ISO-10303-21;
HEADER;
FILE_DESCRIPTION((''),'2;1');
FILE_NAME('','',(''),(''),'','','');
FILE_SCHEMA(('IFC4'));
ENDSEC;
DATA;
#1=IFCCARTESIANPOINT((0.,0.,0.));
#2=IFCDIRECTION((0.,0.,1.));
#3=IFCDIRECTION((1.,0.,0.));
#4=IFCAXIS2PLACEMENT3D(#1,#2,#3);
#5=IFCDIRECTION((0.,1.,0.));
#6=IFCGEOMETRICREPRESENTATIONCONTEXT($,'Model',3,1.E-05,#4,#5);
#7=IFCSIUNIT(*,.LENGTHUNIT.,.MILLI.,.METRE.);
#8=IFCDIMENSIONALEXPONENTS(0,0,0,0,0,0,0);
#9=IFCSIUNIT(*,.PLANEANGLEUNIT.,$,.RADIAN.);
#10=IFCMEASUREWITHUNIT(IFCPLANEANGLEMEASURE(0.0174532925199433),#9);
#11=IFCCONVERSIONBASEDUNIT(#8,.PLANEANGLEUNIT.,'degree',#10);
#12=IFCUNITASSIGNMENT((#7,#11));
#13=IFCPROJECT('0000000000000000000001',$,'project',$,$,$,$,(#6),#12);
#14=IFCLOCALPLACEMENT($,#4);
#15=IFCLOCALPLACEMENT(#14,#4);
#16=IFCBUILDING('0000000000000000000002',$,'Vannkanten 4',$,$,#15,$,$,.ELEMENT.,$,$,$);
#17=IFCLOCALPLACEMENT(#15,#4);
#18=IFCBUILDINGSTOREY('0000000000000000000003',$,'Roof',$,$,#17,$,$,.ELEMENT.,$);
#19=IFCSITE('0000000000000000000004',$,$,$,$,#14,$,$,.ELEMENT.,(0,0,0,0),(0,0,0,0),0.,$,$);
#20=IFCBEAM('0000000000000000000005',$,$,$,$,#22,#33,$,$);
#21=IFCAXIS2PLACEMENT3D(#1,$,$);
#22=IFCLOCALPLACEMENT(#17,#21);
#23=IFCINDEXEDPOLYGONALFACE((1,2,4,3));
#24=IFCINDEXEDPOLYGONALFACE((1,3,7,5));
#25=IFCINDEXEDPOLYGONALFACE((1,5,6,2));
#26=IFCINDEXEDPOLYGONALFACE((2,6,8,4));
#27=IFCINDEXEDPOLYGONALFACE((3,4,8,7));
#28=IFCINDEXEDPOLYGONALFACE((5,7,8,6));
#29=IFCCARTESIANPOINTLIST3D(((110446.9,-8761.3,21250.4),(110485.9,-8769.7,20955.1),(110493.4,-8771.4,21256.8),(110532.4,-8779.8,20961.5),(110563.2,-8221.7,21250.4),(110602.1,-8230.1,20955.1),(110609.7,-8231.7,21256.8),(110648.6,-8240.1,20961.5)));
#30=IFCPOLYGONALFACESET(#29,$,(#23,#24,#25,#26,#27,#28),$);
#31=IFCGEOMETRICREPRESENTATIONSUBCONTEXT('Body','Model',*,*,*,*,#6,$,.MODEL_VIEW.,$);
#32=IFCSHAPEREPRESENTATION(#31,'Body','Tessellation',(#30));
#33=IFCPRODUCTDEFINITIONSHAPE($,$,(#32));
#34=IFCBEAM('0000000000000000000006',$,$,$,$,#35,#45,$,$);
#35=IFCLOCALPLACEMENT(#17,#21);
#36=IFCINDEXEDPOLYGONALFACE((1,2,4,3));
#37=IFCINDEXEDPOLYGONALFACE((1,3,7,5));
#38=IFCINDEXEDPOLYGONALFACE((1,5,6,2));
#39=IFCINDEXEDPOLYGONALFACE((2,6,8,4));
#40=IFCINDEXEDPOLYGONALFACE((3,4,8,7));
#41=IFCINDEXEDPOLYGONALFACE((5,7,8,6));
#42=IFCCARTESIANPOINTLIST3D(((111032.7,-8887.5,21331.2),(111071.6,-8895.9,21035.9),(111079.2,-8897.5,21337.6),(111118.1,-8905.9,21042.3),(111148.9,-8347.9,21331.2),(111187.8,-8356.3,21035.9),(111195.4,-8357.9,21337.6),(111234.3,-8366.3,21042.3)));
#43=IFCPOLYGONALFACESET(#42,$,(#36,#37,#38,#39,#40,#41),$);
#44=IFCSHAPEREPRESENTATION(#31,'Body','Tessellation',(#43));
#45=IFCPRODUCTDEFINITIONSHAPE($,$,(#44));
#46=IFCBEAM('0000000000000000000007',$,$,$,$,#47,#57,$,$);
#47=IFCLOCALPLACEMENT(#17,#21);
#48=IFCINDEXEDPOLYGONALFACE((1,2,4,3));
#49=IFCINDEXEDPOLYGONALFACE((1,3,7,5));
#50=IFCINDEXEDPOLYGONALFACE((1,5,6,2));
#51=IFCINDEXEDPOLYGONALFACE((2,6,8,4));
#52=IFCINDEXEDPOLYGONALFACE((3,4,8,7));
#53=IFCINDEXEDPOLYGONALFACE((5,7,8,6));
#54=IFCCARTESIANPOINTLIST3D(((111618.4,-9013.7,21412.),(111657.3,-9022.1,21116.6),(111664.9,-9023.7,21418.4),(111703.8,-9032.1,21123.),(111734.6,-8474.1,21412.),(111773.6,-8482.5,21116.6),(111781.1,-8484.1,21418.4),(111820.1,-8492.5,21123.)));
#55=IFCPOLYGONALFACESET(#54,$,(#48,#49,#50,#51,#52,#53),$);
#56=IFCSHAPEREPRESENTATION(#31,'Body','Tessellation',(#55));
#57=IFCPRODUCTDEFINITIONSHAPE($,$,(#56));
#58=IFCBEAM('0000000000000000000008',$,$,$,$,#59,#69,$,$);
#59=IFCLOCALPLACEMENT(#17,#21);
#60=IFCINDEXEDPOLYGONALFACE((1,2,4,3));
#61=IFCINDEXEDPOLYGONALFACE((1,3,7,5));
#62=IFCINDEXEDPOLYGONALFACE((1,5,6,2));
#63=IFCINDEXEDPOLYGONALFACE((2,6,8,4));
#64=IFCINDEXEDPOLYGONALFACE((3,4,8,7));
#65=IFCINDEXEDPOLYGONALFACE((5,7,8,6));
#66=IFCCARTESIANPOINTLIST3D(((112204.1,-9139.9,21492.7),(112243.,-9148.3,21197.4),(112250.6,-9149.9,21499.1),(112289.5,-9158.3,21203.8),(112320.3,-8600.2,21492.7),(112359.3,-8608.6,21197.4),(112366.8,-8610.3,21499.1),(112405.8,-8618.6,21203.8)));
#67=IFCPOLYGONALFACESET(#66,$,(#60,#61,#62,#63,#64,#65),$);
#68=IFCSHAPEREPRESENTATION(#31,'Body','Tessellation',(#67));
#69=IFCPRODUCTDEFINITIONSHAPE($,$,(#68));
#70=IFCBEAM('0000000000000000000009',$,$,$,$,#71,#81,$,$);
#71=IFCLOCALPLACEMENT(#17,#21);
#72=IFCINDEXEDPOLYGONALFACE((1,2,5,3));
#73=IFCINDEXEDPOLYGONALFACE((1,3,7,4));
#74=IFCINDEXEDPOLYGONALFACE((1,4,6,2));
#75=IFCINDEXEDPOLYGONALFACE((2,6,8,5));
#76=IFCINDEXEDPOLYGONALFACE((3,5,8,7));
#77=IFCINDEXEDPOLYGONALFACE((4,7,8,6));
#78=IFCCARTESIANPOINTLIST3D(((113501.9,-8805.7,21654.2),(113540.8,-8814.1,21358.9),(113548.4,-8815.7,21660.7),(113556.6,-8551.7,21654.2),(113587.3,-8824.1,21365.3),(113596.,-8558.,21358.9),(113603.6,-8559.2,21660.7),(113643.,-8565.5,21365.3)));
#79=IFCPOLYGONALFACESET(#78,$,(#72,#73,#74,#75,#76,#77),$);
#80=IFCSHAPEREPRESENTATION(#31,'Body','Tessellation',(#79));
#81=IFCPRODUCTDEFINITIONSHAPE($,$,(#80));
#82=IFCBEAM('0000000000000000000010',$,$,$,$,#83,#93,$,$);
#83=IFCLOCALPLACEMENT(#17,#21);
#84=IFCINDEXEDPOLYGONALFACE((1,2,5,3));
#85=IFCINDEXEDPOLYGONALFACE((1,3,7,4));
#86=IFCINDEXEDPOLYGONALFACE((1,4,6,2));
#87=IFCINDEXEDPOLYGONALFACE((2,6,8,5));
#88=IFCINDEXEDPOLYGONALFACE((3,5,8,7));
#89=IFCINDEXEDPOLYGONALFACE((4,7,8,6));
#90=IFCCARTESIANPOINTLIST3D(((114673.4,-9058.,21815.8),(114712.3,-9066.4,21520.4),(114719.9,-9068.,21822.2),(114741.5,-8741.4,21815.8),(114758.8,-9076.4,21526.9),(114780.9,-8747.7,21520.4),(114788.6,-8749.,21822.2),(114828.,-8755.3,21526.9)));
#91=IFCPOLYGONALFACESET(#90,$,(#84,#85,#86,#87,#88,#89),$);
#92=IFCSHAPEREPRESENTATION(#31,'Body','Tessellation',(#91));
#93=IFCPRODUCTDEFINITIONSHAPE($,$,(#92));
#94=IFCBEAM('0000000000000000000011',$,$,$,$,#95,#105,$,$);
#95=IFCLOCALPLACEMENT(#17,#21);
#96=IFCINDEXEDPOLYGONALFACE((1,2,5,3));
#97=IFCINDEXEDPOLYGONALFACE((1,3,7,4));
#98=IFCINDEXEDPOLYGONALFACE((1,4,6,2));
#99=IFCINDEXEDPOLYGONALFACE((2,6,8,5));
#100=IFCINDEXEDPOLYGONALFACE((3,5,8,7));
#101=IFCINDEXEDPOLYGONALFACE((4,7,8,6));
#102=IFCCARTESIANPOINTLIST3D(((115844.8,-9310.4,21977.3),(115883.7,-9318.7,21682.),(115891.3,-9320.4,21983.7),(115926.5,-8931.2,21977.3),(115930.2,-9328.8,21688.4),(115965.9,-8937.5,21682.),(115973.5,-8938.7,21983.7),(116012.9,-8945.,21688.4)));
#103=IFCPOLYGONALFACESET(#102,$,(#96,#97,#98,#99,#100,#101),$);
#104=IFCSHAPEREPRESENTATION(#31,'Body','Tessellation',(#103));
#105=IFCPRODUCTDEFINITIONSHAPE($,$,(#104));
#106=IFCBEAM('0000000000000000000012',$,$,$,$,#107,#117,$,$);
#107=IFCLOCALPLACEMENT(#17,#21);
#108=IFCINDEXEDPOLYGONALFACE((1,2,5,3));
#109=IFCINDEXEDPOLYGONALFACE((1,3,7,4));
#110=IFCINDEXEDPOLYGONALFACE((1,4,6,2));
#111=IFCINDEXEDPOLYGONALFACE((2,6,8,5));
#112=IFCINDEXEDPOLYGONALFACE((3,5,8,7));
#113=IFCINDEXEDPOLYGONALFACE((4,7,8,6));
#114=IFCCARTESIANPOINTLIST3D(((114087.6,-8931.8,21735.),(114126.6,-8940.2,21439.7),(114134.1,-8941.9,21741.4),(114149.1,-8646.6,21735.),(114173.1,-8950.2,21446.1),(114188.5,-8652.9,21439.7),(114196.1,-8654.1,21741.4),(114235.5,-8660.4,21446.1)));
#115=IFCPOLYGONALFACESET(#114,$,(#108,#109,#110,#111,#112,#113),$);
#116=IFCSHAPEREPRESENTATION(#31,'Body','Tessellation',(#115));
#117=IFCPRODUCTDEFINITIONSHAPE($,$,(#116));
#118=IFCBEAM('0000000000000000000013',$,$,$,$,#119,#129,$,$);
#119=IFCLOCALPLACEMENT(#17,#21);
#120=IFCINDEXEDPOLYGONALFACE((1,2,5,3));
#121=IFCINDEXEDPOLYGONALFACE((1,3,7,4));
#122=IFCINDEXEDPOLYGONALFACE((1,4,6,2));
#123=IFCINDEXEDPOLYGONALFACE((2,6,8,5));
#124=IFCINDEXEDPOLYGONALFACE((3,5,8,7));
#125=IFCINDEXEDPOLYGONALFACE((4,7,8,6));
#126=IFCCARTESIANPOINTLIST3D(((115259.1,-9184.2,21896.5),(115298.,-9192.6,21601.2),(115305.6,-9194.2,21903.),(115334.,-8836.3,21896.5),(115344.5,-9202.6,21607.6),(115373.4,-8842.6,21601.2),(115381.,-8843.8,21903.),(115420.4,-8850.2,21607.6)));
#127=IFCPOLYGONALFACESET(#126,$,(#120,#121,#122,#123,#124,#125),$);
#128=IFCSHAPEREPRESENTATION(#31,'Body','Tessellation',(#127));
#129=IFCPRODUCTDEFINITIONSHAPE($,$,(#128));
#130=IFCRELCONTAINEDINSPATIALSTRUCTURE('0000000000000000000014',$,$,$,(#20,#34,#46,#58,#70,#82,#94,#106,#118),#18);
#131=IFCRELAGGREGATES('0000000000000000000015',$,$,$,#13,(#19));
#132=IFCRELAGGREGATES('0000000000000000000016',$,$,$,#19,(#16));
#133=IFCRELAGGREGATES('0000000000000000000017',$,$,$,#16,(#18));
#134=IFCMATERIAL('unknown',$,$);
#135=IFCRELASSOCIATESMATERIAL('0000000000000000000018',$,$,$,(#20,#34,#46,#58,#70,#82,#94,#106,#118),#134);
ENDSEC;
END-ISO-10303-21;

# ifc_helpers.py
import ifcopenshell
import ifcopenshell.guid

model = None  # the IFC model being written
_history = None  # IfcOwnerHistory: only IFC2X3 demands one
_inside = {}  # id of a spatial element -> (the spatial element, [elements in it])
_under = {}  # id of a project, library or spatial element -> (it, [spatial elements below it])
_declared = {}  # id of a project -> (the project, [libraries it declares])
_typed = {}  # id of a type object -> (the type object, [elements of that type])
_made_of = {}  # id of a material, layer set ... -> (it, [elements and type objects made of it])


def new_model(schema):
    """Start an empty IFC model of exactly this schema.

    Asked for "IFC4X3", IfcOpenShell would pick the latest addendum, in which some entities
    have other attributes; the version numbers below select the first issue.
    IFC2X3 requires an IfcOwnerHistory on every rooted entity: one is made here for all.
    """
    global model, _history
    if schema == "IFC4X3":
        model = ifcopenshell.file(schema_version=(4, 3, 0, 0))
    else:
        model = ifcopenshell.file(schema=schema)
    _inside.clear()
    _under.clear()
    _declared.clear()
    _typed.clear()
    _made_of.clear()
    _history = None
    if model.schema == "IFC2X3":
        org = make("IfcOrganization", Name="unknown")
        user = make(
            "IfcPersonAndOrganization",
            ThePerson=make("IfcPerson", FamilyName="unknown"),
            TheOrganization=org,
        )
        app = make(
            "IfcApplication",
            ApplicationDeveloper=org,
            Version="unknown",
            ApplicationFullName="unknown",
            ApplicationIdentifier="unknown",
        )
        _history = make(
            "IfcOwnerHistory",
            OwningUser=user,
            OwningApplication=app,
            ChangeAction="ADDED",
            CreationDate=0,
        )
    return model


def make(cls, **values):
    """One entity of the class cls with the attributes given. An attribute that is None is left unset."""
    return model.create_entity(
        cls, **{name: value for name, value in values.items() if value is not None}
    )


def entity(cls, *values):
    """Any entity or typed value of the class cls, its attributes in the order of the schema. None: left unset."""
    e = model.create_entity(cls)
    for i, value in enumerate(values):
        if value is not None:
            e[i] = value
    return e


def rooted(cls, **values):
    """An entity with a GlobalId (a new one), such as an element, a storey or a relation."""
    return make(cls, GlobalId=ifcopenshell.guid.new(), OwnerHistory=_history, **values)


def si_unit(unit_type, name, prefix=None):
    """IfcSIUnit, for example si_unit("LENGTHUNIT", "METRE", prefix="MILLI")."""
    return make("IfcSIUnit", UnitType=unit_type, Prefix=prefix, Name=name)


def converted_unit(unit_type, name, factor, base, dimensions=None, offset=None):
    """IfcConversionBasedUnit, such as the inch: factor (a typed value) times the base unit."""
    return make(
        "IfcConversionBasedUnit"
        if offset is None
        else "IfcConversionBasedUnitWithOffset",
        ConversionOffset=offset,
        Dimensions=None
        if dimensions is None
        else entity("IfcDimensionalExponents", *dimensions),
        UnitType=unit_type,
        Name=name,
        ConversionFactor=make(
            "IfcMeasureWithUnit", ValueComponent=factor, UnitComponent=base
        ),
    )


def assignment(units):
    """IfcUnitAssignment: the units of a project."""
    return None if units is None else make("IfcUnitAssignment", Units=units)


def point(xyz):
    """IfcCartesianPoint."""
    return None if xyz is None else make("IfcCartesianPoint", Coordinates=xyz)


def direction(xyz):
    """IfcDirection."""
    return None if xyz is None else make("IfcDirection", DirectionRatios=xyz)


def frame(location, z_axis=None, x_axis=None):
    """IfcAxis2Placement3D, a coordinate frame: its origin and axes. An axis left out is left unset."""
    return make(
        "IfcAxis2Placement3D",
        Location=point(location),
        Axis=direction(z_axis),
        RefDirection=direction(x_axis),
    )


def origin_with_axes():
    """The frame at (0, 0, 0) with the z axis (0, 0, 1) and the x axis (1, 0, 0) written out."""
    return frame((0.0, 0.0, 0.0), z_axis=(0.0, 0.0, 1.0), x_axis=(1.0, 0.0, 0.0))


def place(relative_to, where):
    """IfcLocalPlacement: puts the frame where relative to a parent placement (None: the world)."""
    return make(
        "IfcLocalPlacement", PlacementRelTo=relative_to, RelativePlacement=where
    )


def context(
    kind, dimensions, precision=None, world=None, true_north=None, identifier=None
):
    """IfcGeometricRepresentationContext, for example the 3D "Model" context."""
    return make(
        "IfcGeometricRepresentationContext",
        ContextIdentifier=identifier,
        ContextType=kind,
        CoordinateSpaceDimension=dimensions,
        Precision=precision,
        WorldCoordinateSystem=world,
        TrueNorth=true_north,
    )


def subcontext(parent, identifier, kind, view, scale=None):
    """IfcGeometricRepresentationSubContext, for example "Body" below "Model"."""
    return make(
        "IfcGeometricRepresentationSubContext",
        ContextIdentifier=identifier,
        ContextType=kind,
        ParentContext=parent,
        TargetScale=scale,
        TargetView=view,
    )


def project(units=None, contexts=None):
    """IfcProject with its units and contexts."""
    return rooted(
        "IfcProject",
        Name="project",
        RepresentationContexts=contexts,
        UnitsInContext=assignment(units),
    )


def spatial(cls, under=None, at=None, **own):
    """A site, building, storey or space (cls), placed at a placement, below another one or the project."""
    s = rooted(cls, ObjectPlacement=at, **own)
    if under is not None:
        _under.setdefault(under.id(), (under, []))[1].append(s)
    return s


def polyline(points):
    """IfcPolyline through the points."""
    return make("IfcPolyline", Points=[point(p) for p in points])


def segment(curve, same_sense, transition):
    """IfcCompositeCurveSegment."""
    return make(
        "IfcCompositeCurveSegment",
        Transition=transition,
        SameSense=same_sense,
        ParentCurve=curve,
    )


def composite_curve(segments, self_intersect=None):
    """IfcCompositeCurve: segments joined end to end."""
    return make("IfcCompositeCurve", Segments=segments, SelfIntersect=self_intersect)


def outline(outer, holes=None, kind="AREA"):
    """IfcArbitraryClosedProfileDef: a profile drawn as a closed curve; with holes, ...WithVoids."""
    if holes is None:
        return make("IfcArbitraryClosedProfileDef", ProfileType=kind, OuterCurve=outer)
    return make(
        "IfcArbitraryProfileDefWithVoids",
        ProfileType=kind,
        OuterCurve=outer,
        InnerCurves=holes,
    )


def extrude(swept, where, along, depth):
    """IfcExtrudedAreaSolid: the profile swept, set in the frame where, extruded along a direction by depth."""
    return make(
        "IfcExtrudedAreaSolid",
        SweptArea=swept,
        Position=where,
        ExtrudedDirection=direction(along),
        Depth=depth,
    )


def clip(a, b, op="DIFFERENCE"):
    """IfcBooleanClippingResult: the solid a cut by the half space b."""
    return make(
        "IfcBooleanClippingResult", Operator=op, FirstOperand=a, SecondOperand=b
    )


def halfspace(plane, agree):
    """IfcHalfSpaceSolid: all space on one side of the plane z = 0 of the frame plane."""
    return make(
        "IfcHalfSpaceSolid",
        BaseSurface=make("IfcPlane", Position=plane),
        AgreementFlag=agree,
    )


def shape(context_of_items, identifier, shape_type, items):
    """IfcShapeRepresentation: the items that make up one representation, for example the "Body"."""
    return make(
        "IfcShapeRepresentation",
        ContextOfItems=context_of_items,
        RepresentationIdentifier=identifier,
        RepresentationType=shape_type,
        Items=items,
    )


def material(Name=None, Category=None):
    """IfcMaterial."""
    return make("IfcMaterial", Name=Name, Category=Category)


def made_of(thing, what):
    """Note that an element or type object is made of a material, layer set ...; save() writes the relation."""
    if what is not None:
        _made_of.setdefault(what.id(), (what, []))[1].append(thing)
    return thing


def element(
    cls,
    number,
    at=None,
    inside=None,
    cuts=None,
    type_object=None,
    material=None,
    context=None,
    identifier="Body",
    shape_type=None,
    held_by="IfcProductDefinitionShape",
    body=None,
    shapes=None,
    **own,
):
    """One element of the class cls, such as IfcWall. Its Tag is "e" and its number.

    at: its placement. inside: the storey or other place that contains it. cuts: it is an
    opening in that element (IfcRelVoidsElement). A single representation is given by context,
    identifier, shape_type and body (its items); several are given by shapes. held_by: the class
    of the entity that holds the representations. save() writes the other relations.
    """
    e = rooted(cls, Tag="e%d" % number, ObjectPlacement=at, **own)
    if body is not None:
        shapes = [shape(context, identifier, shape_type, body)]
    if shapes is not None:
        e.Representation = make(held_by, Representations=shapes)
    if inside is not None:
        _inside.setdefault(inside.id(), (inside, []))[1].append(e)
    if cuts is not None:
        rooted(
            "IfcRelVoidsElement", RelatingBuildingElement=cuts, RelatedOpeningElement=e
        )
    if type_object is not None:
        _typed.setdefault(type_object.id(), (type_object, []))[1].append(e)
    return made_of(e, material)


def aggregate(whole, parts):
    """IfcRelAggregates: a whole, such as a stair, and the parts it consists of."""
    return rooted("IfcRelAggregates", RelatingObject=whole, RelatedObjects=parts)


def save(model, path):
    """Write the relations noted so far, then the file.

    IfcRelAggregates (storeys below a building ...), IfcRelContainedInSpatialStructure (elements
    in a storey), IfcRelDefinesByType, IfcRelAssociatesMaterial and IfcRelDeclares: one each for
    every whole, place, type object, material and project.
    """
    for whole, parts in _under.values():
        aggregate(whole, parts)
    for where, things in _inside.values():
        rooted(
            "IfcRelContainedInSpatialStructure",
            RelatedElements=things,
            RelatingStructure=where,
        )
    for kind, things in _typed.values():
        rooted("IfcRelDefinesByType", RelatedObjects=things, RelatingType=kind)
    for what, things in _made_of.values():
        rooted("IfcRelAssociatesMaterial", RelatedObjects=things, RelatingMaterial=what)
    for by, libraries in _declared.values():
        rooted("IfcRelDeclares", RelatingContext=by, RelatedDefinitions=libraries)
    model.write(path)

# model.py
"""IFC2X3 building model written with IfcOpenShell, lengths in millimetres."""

from ifc_helpers import new_model, entity, si_unit, converted_unit, direction, frame, origin_with_axes, place, context, subcontext, project, spatial, polyline, segment, composite_curve, outline, extrude, clip, halfspace, material, element, save


model = new_model("IFC2X3")

# Units and contexts
model_context = context("Model", 3, precision=1e-05, world=origin_with_axes(), true_north=direction((0.0, 1.0, 0.0)))
body_context = subcontext(model_context, "Body", "Model", "MODEL_VIEW")
ifc_project = project(units=[si_unit("LENGTHUNIT", "METRE", prefix="MILLI"), converted_unit("PLANEANGLEUNIT", "degree", entity("IfcPlaneAngleMeasure", 0.0174532925199433), si_unit("PLANEANGLEUNIT", "RADIAN"), dimensions=[0, 0, 0, 0, 0, 0, 0])], contexts=[model_context])

# Site, building, storey
site_placement = place(None, origin_with_axes())
site = spatial("IfcSite", under=ifc_project, at=site_placement, CompositionType="ELEMENT", RefLatitude=(0, 0, 0, 0), RefLongitude=(0, 0, 0, 0), RefElevation=0.0)
building_placement = place(site_placement, origin_with_axes())
building = spatial("IfcBuilding", under=site, at=building_placement, Name="Vannkanten 4", CompositionType="ELEMENT")
storey_placement = place(building_placement, origin_with_axes())
storey = spatial("IfcBuildingStorey", under=building, at=storey_placement, Name="Roof", CompositionType="ELEMENT")

# Shared definitions
ifc_material = material(Name="unknown")

# Beams
beam_1_placement = place(storey_placement, frame((110489.6, -8770.6, 21106.0), z_axis=(0.210582, 0.977576, 0.0), x_axis=(-0.968803, 0.208692, -0.133675)))
element("IfcBeam", 1, at=beam_1_placement, inside=storey, material=ifc_material, context=body_context, shape_type="SweptSolid", body=[
    extrude(outline(composite_curve([segment(polyline([(-24.0, -149.0), (-24.0, 149.0), (24.0, 149.0), (24.0, -149.0), (-24.0, -149.0)]), True, "CONTINUOUS")], self_intersect=False)), frame((0.0, 0.0, 0.0), z_axis=(0.0, 0.0, 1.0), x_axis=(1.0, 0.0, 0.0)), (0.0, 0.0, 1.0), 552.0),
])
beam_2_placement = place(storey_placement, frame((111075.4, -8896.7, 21186.7), z_axis=(0.210582, 0.977576, 0.0), x_axis=(-0.968803, 0.208692, -0.133675)))
element("IfcBeam", 2, at=beam_2_placement, inside=storey, material=ifc_material, context=body_context, shape_type="SweptSolid", body=[
    extrude(outline(composite_curve([segment(polyline([(-24.0, -149.0), (-24.0, 149.0), (24.0, 149.0), (24.0, -149.0), (-24.0, -149.0)]), True, "CONTINUOUS")], self_intersect=False)), frame((0.0, 0.0, 0.0), z_axis=(0.0, 0.0, 1.0), x_axis=(1.0, 0.0, 0.0)), (0.0, 0.0, 1.0), 552.0),
])
beam_3_placement = place(storey_placement, frame((111661.1, -9022.9, 21267.5), z_axis=(0.210582, 0.977576, 0.0), x_axis=(-0.968803, 0.208692, -0.133675)))
element("IfcBeam", 3, at=beam_3_placement, inside=storey, material=ifc_material, context=body_context, shape_type="SweptSolid", body=[
    extrude(outline(composite_curve([segment(polyline([(-24.0, -149.0), (-24.0, 149.0), (24.0, 149.0), (24.0, -149.0), (-24.0, -149.0)]), True, "CONTINUOUS")], self_intersect=False)), frame((0.0, 0.0, 0.0), z_axis=(0.0, 0.0, 1.0), x_axis=(1.0, 0.0, 0.0)), (0.0, 0.0, 1.0), 552.0),
])
beam_4_placement = place(storey_placement, frame((112246.8, -9149.1, 21348.3), z_axis=(0.210582, 0.977576, 0.0), x_axis=(-0.968803, 0.208692, -0.133675)))
element("IfcBeam", 4, at=beam_4_placement, inside=storey, material=ifc_material, context=body_context, shape_type="SweptSolid", body=[
    extrude(outline(composite_curve([segment(polyline([(-24.0, -149.0), (-24.0, 149.0), (24.0, 149.0), (24.0, -149.0), (-24.0, -149.0)]), True, "CONTINUOUS")], self_intersect=False)), frame((0.0, 0.0, 0.0), z_axis=(0.0, 0.0, 1.0), x_axis=(1.0, 0.0, 0.0)), (0.0, 0.0, 1.0), 552.0),
])
beam_5_placement = place(storey_placement, frame((113544.6, -8814.9, 21509.8), z_axis=(0.210582, 0.977576, 0.0), x_axis=(-0.968803, 0.208692, -0.133675)))
element("IfcBeam", 5, at=beam_5_placement, inside=storey, material=ifc_material, context=body_context, shape_type="Clipping", body=[
    clip(extrude(outline(composite_curve([segment(polyline([(-24.0, -149.0), (-24.0, 149.0), (24.0, 149.0), (24.0, -149.0), (-24.0, -149.0)]), True, "CONTINUOUS")], self_intersect=False)), frame((0.0, 0.0, 0.0), z_axis=(0.0, 0.0, 1.0), x_axis=(1.0, 0.0, 0.0)), (0.0, 0.0, 1.0), 396.7), halfspace(frame((-24.0, -149.0, 264.5), z_axis=(-0.052883, -0.007133, -0.998575), x_axis=(-0.998601, 0.0, 0.052884)), True)),
])
beam_6_placement = place(storey_placement, frame((114716.1, -9067.2, 21671.3), z_axis=(0.210582, 0.977576, 0.0), x_axis=(-0.968803, 0.208692, -0.133675)))
element("IfcBeam", 6, at=beam_6_placement, inside=storey, material=ifc_material, context=body_context, shape_type="Clipping", body=[
    clip(extrude(outline(composite_curve([segment(polyline([(-24.0, -149.0), (-24.0, 149.0), (24.0, 149.0), (24.0, -149.0), (-24.0, -149.0)]), True, "CONTINUOUS")], self_intersect=False)), frame((0.0, 0.0, 0.0), z_axis=(0.0, 0.0, 1.0), x_axis=(1.0, 0.0, 0.0)), (0.0, 0.0, 1.0), 492.8), halfspace(frame((-24.0, -149.0, 328.5), z_axis=(-0.052883, -0.007133, -0.998575), x_axis=(-0.998601, 0.0, 0.052884)), True)),
])
beam_7_placement = place(storey_placement, frame((115887.5, -9319.6, 21832.8), z_axis=(0.210582, 0.977576, 0.0), x_axis=(-0.968803, 0.208692, -0.133675)))
element("IfcBeam", 7, at=beam_7_placement, inside=storey, material=ifc_material, context=body_context, shape_type="Clipping", body=[
    clip(extrude(outline(composite_curve([segment(polyline([(-24.0, -149.0), (-24.0, 149.0), (24.0, 149.0), (24.0, -149.0), (-24.0, -149.0)]), True, "CONTINUOUS")], self_intersect=False)), frame((0.0, 0.0, 0.0), z_axis=(0.0, 0.0, 1.0), x_axis=(1.0, 0.0, 0.0)), (0.0, 0.0, 1.0), 588.8), halfspace(frame((-24.0, -149.0, 392.5), z_axis=(-0.052883, -0.007133, -0.998575), x_axis=(-0.998601, 0.0, 0.052884)), True)),
])
beam_8_placement = place(storey_placement, frame((114130.3, -8941.0, 21590.6), z_axis=(0.210582, 0.977576, 0.0), x_axis=(-0.968803, 0.208692, -0.133675)))
element("IfcBeam", 8, at=beam_8_placement, inside=storey, material=ifc_material, context=body_context, shape_type="Clipping", body=[
    clip(extrude(outline(composite_curve([segment(polyline([(-24.0, -149.0), (-24.0, 149.0), (24.0, 149.0), (24.0, -149.0), (-24.0, -149.0)]), True, "CONTINUOUS")], self_intersect=False)), frame((0.0, 0.0, 0.0), z_axis=(0.0, 0.0, 1.0), x_axis=(1.0, 0.0, 0.0)), (0.0, 0.0, 1.0), 444.7), halfspace(frame((-24.0, -149.0, 296.5), z_axis=(-0.052883, -0.007133, -0.998575), x_axis=(-0.998601, 0.0, 0.052884)), True)),
])
beam_9_placement = place(storey_placement, frame((115301.8, -9193.4, 21752.1), z_axis=(0.210582, 0.977576, 0.0), x_axis=(-0.968803, 0.208692, -0.133675)))
element("IfcBeam", 9, at=beam_9_placement, inside=storey, material=ifc_material, context=body_context, shape_type="Clipping", body=[
    clip(extrude(outline(composite_curve([segment(polyline([(-24.0, -149.0), (-24.0, 149.0), (24.0, 149.0), (24.0, -149.0), (-24.0, -149.0)]), True, "CONTINUOUS")], self_intersect=False)), frame((0.0, 0.0, 0.0), z_axis=(0.0, 0.0, 1.0), x_axis=(1.0, 0.0, 0.0)), (0.0, 0.0, 1.0), 540.8), halfspace(frame((-24.0, -149.0, 360.5), z_axis=(-0.052883, -0.007133, -0.998575), x_axis=(-0.998601, 0.0, 0.052884)), True)),
])

save(model, "model.ifc")
